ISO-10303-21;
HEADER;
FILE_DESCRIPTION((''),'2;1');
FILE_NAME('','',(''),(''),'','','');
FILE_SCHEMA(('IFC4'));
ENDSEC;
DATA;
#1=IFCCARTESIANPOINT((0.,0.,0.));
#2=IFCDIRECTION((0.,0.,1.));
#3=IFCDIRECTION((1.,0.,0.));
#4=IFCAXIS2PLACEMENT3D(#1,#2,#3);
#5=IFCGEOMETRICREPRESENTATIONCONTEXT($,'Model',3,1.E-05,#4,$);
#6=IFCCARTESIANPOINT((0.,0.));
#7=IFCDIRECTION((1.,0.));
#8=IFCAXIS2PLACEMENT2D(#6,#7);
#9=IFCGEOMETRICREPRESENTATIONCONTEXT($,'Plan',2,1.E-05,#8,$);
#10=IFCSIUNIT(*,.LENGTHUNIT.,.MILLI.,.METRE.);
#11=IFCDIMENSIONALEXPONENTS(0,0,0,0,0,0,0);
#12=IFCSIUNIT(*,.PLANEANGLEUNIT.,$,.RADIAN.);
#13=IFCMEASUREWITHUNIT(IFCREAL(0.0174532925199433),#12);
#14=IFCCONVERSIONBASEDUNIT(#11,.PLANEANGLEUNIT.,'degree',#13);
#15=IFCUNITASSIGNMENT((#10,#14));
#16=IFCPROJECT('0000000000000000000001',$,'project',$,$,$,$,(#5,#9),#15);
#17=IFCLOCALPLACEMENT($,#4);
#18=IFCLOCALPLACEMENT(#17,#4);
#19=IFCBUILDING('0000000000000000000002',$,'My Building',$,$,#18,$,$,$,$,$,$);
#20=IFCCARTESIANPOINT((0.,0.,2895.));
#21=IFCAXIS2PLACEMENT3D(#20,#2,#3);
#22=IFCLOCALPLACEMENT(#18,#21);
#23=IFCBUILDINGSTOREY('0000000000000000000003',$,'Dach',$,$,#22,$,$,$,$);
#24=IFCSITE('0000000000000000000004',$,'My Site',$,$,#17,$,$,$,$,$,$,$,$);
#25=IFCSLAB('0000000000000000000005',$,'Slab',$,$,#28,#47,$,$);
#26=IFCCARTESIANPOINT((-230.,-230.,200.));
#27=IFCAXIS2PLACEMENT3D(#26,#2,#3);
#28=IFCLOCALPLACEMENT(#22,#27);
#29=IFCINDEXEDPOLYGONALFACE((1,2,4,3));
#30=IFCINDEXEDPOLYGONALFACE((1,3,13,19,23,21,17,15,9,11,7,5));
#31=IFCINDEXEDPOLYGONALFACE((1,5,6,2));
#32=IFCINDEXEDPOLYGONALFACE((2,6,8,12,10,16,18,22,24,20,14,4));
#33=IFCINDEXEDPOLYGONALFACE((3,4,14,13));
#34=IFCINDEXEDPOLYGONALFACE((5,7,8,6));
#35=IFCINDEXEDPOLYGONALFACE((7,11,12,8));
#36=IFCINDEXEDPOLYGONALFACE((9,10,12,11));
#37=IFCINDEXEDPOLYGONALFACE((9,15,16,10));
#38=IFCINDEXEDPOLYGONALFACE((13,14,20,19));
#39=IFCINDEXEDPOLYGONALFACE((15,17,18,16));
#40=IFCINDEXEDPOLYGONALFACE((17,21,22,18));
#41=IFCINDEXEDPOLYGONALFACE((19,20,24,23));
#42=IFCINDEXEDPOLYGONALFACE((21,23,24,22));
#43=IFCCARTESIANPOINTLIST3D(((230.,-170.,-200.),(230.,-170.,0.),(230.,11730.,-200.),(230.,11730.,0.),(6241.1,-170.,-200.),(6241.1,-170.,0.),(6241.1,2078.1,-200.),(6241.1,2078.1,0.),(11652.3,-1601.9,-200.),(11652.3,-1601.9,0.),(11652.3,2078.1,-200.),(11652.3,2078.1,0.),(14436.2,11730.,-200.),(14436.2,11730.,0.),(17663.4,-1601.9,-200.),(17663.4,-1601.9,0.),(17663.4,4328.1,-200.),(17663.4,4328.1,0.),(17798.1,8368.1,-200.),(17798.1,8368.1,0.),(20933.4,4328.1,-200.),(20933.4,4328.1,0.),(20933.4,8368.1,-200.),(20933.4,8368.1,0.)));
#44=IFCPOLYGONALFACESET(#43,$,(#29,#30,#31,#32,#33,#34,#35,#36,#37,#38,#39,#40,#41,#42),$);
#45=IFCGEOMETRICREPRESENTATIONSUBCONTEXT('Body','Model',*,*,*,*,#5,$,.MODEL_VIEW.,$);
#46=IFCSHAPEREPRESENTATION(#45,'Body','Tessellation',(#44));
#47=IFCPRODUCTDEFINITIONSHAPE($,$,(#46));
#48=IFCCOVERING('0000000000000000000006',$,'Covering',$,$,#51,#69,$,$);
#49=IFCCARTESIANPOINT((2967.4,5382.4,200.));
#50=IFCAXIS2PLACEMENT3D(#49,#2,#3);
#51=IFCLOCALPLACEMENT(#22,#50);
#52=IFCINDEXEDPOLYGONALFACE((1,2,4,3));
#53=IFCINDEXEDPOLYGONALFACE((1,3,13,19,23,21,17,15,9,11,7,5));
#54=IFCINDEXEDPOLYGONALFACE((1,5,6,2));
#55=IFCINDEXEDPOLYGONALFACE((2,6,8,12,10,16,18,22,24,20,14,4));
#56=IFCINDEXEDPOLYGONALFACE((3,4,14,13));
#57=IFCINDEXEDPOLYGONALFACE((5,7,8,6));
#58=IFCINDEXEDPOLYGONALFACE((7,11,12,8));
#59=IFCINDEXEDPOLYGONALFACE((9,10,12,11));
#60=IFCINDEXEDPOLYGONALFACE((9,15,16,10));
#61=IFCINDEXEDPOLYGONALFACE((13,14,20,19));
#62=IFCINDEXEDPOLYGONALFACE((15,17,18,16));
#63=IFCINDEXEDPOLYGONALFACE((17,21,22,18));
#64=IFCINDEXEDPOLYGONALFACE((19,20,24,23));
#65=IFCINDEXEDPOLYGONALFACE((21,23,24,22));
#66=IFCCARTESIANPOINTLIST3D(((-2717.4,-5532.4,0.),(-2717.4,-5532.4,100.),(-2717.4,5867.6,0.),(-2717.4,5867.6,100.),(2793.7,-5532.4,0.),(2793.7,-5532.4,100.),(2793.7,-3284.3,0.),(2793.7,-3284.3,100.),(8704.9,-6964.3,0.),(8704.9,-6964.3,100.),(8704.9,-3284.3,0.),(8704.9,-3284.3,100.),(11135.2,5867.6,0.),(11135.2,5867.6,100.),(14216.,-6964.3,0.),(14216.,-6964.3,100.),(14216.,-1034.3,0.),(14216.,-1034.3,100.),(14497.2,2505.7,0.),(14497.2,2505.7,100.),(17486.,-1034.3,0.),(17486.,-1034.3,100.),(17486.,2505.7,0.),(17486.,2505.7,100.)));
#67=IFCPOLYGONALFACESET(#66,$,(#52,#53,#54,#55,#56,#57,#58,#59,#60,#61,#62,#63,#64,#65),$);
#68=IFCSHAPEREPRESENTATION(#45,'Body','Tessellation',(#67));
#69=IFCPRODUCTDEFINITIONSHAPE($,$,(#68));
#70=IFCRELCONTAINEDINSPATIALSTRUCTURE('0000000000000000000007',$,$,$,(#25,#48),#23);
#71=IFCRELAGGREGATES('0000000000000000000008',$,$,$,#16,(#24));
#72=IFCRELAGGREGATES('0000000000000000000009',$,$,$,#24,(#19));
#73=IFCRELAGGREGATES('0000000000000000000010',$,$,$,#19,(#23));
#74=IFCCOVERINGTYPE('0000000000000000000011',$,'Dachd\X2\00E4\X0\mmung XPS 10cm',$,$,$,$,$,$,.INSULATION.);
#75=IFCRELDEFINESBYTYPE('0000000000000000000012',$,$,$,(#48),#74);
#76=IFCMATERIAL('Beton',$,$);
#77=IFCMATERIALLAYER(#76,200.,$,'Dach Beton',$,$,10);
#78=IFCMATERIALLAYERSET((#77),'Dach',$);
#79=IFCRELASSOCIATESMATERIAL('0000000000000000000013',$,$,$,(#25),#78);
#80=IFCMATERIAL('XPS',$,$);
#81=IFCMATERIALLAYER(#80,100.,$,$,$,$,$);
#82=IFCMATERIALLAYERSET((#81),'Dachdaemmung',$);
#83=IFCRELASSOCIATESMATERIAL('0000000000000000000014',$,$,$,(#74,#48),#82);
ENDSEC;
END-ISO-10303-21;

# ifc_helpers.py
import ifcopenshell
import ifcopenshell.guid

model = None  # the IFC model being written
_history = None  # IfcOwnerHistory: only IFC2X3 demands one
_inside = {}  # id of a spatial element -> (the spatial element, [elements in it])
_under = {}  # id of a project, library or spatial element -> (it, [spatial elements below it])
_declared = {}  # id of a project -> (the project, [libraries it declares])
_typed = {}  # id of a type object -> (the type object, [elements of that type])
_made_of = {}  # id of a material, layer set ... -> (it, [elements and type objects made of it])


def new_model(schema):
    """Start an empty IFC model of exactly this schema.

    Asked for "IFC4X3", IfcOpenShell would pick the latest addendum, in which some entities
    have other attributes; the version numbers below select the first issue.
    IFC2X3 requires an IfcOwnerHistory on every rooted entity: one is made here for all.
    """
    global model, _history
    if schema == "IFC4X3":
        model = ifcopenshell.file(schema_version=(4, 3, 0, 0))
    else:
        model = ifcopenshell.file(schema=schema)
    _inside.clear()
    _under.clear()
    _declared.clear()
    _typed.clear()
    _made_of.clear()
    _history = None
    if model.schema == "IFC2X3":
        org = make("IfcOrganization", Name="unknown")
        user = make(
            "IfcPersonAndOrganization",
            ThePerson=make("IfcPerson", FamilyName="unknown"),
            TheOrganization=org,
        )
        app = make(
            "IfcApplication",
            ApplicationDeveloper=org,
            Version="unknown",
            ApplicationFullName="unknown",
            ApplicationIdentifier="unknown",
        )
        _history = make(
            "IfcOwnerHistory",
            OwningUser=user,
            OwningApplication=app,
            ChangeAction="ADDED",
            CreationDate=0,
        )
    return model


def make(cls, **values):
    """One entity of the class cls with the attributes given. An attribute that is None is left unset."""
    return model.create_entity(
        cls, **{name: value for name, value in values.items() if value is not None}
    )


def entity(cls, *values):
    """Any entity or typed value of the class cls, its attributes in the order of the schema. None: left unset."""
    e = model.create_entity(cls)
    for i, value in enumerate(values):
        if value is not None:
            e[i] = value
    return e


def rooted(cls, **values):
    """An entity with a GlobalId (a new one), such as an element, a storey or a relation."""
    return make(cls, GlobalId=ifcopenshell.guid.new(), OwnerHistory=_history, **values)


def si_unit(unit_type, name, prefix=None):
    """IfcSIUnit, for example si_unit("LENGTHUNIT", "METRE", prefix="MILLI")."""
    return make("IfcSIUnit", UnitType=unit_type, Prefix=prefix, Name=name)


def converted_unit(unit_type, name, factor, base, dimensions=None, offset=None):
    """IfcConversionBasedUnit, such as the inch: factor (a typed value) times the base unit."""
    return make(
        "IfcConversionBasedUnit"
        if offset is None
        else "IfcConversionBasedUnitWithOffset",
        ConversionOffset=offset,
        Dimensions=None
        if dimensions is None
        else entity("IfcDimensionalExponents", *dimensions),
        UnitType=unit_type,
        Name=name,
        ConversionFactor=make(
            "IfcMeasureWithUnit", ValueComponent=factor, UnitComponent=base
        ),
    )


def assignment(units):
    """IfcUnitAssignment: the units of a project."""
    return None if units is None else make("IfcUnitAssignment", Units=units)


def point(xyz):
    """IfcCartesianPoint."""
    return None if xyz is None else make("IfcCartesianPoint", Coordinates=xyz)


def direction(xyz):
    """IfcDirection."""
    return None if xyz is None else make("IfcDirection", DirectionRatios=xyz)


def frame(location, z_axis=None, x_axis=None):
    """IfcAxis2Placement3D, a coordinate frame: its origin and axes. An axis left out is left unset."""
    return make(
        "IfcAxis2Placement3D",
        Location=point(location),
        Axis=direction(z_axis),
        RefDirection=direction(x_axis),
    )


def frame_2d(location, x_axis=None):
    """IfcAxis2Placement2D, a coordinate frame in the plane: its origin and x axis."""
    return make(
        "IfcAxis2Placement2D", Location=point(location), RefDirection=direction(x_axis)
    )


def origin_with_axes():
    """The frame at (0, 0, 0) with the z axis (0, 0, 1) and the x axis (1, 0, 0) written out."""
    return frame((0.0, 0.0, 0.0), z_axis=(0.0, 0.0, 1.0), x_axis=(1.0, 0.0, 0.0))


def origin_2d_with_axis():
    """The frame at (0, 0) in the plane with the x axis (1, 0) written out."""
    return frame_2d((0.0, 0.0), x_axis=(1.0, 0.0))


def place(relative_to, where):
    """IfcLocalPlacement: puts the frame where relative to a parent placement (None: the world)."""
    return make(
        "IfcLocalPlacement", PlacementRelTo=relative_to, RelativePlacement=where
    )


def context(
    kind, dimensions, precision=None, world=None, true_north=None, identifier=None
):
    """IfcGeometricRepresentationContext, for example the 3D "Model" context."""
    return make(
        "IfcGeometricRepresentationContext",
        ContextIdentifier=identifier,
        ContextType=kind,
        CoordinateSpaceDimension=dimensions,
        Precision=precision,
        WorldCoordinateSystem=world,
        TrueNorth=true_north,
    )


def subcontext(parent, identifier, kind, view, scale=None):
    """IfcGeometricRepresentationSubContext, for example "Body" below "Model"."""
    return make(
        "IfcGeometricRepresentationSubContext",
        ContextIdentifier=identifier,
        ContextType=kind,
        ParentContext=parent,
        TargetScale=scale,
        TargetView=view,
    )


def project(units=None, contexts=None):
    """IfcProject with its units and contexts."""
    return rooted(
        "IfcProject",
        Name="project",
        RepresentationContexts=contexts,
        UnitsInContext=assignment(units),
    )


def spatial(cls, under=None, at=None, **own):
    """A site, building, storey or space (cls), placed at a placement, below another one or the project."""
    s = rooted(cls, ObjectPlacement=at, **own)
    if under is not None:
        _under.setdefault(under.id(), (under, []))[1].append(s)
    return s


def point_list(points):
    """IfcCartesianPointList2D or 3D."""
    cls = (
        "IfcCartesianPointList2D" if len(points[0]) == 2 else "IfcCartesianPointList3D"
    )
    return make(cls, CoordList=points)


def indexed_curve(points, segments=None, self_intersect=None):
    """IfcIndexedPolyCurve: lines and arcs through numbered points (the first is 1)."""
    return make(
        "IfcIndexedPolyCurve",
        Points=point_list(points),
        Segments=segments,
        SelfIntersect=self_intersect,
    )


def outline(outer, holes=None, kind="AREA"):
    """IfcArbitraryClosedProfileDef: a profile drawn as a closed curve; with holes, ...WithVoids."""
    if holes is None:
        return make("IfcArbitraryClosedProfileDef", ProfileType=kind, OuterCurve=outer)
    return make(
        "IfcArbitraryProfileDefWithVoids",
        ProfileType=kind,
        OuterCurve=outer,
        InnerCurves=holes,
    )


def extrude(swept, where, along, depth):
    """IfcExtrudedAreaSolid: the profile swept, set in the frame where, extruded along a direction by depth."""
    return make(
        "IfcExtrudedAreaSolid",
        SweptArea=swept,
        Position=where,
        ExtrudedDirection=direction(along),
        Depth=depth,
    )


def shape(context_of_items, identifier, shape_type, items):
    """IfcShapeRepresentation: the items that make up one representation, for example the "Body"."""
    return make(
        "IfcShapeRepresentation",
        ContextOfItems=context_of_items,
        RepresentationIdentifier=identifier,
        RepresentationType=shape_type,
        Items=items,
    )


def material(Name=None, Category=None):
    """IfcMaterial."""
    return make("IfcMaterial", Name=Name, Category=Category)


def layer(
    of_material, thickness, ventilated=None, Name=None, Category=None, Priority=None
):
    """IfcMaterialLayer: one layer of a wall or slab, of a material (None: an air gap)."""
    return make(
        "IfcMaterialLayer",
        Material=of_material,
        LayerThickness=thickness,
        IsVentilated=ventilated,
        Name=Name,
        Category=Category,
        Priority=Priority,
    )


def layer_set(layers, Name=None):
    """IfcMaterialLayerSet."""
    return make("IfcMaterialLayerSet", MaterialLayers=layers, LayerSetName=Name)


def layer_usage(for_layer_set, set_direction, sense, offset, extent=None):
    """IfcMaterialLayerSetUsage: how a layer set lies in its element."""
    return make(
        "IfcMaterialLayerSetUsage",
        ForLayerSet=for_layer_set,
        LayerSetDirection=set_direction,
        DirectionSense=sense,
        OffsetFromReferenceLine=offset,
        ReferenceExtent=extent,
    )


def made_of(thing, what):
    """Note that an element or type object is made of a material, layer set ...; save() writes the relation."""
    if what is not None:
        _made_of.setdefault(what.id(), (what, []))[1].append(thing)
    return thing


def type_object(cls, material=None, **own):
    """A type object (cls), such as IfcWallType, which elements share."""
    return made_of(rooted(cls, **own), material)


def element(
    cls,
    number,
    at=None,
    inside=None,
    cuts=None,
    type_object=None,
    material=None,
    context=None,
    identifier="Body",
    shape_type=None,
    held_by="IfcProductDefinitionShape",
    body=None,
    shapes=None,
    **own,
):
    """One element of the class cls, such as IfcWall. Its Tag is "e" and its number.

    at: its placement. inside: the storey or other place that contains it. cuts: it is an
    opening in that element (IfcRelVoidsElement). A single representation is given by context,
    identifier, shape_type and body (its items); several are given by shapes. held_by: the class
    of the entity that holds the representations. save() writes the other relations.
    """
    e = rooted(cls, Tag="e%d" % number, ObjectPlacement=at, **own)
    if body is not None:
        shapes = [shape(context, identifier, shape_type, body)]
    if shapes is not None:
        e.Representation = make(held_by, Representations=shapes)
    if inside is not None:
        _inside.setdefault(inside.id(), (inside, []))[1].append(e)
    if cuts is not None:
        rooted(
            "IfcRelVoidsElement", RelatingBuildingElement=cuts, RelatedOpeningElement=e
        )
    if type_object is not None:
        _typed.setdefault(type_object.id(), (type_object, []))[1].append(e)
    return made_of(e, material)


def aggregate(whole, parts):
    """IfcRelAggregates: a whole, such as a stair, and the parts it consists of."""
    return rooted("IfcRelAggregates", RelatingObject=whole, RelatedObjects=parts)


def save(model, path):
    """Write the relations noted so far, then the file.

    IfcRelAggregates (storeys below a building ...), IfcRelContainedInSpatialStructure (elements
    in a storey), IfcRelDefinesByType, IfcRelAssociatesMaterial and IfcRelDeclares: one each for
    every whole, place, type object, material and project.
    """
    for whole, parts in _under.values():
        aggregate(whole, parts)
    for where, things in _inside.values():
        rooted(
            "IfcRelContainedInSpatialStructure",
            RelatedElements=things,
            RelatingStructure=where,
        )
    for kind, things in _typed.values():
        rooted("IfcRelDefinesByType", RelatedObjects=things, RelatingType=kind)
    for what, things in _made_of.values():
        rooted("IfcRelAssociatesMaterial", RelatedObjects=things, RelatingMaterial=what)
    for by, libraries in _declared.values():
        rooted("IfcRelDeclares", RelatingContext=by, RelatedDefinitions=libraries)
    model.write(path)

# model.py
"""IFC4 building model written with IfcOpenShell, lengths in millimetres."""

from ifc_helpers import new_model, entity, si_unit, converted_unit, frame, origin_with_axes, origin_2d_with_axis, place, context, subcontext, project, spatial, indexed_curve, outline, extrude, material, layer, layer_set, layer_usage, type_object, element, save


model = new_model("IFC4")

# Units and contexts
model_context = context("Model", 3, precision=1e-05, world=origin_with_axes())
plan_context = context("Plan", 2, precision=1e-05, world=origin_2d_with_axis())
body_context = subcontext(model_context, "Body", "Model", "MODEL_VIEW")
ifc_project = project(units=[si_unit("LENGTHUNIT", "METRE", prefix="MILLI"), converted_unit("PLANEANGLEUNIT", "degree", entity("IfcReal", 0.0174532925199433), si_unit("PLANEANGLEUNIT", "RADIAN"), dimensions=[0, 0, 0, 0, 0, 0, 0])], contexts=[model_context, plan_context])

# Site, building, storey
site_placement = place(None, origin_with_axes())
site = spatial("IfcSite", under=ifc_project, at=site_placement, Name="My Site")
building_placement = place(site_placement, origin_with_axes())
building = spatial("IfcBuilding", under=site, at=building_placement, Name="My Building")
storey_placement = place(building_placement, frame((0.0, 0.0, 2895.0), z_axis=(0.0, 0.0, 1.0), x_axis=(1.0, 0.0, 0.0)))
storey = spatial("IfcBuildingStorey", under=building, at=storey_placement, Name="Dach")

# Slab
ifc_material_1 = material(Name="Beton")
ifc_layer_1 = layer(ifc_material_1, 200.0, Name="Dach Beton", Priority=10)
ifc_layer_set_1 = layer_set([ifc_layer_1], Name="Dach")
ifc_layer_usage_1 = layer_usage(ifc_layer_set_1, "AXIS3", "POSITIVE", -200.0)
slab_placement = place(storey_placement, frame((-230.0, -230.0, 200.0), z_axis=(0.0, 0.0, 1.0), x_axis=(1.0, 0.0, 0.0)))
element("IfcSlab", 1, at=slab_placement, inside=storey, material=ifc_layer_usage_1, Name="Slab", context=body_context, shape_type="SweptSolid", body=[
    extrude(outline(indexed_curve([(230.0, -170.0), (230.0, 11730.0), (14436.2, 11730.0), (17798.1, 8368.1), (20933.4, 8368.1), (20933.4, 4328.1), (17663.4, 4328.1), (17663.4, -1601.9), (11652.3, -1601.9), (11652.3, 2078.1), (6241.1, 2078.1), (6241.1, -170.0), (230.0, -170.0)])), frame((0.0, 0.0, -200.0), z_axis=(0.0, 0.0, 1.0), x_axis=(1.0, 0.0, 0.0)), (0.0, 0.0, 1.0), 200.0),
])

# Covering
ifc_material_2 = material(Name="XPS")
ifc_layer_2 = layer(ifc_material_2, 100.0)
ifc_layer_set_2 = layer_set([ifc_layer_2], Name="Dachdaemmung")
ifc_layer_usage_2 = layer_usage(ifc_layer_set_2, "AXIS3", "POSITIVE", 0.0)
covering_type = type_object("IfcCoveringType", Name="Dachdämmung XPS 10cm", PredefinedType="INSULATION", material=ifc_layer_set_2)
covering_1_placement = place(storey_placement, frame((2967.4, 5382.4, 200.0), z_axis=(0.0, 0.0, 1.0), x_axis=(1.0, 0.0, 0.0)))
element("IfcCovering", 2, at=covering_1_placement, inside=storey, type_object=covering_type, material=ifc_layer_usage_2, Name="Covering", context=body_context, shape_type="SweptSolid", body=[
    extrude(outline(indexed_curve([(8704.9, -3284.3), (8704.9, -6964.3), (14216.0, -6964.3), (14216.0, -1034.3), (17486.0, -1034.3), (17486.0, 2505.7), (14497.2, 2505.7), (11135.2, 5867.6), (-2717.4, 5867.6), (-2717.4, -5532.4), (2793.7, -5532.4), (2793.7, -3284.3), (8704.9, -3284.3)])), None, (0.0, 0.0, 1.0), 100.0),
])

save(model, "model.ifc")
